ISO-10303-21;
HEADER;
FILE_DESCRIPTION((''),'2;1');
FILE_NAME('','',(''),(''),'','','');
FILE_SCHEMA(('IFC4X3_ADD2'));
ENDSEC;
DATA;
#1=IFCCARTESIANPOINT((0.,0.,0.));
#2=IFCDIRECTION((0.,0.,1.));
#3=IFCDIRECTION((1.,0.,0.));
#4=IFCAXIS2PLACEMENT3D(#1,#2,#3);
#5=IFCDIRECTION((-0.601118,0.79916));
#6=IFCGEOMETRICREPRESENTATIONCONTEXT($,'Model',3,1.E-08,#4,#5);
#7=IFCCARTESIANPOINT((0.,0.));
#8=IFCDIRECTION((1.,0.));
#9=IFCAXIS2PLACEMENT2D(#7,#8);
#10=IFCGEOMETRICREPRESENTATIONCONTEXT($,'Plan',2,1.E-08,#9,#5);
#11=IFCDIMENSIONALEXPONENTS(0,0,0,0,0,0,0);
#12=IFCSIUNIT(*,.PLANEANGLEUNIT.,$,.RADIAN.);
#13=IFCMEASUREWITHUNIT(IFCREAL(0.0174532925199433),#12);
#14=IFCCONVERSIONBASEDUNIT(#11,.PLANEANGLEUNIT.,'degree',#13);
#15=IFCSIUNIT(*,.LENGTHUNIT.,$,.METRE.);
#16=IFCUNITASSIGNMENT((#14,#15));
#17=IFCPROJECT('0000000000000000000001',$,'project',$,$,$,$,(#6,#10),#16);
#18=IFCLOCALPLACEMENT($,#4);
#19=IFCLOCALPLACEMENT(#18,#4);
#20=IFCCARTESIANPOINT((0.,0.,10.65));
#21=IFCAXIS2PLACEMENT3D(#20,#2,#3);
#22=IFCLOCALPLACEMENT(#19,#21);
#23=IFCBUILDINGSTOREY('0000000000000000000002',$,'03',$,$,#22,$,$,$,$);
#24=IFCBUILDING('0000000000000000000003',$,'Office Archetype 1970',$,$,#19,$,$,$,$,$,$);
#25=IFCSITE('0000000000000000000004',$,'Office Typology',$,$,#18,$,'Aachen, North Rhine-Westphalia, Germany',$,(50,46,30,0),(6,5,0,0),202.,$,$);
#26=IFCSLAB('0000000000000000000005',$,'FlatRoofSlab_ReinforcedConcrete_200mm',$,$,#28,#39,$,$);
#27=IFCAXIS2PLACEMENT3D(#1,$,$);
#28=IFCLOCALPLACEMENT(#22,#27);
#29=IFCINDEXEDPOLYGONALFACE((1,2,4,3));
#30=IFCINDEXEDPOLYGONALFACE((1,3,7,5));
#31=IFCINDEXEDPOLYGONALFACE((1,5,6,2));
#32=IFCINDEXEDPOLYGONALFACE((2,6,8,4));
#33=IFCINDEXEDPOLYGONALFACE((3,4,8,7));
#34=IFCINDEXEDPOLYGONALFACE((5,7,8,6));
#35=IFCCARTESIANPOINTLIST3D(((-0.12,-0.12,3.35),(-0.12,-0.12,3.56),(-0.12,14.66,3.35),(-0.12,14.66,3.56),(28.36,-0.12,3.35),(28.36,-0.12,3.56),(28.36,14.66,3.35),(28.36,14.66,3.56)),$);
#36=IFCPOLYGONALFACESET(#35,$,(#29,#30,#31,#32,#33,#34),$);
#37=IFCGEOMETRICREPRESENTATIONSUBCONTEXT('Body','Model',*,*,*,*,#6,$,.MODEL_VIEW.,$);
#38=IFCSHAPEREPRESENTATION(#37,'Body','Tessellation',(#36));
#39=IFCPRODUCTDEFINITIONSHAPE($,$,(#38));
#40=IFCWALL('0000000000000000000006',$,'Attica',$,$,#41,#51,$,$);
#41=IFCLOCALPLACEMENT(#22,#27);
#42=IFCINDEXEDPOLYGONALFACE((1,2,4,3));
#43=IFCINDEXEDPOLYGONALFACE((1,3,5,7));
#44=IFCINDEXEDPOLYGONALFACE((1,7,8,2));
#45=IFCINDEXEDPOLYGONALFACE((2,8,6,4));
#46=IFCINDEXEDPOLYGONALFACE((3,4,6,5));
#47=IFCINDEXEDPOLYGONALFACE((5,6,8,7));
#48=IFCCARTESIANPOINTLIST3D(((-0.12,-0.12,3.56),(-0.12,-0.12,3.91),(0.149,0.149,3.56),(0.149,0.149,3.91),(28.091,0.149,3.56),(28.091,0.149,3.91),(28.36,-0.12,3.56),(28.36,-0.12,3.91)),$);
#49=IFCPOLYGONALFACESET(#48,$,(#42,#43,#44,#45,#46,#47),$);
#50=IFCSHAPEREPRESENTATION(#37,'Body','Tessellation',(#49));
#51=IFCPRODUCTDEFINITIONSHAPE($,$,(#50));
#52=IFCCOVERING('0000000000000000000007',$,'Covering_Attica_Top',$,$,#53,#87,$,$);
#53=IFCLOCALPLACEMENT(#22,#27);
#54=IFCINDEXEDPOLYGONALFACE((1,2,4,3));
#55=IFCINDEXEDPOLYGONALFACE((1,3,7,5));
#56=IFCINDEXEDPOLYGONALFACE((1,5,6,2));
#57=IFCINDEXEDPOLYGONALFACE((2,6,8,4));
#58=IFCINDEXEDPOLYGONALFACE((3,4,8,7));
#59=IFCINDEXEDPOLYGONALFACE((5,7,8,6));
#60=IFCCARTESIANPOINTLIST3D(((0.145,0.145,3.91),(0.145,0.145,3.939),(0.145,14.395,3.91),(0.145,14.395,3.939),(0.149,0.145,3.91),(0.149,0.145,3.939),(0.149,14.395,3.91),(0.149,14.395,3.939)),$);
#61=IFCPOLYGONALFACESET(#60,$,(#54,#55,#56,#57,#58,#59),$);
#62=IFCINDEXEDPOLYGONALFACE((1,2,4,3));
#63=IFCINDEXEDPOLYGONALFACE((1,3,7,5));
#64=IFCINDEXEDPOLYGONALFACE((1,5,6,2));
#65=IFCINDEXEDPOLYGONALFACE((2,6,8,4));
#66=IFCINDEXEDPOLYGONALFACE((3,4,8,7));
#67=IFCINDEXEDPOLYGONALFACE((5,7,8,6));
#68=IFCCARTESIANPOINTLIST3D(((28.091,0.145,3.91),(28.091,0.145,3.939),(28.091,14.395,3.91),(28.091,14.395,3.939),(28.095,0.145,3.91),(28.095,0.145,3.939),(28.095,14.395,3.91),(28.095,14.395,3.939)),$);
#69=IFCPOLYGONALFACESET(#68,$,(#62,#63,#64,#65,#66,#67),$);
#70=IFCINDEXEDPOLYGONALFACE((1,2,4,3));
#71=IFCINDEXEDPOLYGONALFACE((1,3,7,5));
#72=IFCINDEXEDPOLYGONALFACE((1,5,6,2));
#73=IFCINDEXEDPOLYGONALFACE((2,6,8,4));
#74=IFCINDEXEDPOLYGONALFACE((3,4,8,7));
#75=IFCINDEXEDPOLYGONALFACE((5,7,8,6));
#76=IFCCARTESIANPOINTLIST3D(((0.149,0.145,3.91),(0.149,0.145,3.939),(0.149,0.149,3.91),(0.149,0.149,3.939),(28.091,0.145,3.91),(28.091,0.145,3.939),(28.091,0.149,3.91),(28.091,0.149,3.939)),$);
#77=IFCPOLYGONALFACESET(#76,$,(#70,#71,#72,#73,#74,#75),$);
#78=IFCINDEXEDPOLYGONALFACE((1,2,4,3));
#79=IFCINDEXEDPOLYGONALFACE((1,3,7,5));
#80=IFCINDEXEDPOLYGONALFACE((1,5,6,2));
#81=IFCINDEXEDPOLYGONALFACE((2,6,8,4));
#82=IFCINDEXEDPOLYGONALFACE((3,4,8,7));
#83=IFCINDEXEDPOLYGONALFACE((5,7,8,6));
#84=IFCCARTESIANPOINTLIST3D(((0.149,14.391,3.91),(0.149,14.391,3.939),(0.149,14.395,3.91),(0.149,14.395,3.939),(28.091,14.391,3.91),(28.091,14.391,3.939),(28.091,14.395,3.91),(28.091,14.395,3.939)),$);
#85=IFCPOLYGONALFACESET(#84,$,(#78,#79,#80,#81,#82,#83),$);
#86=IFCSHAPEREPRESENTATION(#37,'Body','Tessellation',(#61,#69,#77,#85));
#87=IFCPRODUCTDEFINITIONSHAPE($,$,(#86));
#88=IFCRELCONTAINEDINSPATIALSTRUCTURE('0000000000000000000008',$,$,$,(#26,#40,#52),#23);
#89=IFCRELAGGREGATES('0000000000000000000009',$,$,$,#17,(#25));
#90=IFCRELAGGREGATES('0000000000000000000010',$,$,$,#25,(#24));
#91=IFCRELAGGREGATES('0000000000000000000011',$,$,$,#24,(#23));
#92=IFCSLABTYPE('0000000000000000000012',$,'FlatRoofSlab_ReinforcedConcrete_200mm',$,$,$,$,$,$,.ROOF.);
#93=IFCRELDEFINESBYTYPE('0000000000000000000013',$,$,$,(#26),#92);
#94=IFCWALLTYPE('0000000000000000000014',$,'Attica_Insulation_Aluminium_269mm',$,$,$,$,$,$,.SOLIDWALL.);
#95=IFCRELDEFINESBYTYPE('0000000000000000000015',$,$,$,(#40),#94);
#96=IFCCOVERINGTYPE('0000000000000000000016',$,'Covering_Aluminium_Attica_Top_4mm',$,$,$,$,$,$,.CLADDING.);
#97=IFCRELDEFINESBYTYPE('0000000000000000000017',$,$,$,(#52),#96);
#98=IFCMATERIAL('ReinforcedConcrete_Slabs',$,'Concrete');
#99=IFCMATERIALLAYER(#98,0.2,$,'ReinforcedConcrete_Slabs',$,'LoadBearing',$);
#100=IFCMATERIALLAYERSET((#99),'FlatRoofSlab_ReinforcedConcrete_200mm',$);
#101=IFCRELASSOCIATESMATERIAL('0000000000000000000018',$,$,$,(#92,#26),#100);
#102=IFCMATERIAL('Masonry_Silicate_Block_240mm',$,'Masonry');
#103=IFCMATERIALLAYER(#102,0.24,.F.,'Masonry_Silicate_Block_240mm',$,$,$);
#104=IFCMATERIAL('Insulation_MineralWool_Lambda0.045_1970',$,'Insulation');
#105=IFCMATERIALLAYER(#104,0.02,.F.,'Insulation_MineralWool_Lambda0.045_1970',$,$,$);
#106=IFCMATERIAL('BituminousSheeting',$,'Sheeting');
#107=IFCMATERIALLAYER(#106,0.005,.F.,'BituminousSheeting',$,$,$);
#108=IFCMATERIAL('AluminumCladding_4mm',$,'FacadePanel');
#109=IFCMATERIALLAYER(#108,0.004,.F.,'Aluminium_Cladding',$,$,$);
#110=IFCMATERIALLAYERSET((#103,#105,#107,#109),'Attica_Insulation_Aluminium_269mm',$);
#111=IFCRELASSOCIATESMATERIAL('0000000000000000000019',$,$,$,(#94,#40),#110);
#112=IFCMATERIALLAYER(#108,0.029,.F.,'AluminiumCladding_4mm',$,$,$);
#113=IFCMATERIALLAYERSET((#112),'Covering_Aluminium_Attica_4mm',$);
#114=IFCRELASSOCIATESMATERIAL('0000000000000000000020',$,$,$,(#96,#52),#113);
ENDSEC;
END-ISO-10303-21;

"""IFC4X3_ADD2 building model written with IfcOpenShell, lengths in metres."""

from ifc_helpers import new_model, entity, si_unit, converted_unit, direction, frame, origin_with_axes, origin_2d_with_axis, place, context, subcontext, project, spatial, line, indexed_curve, outline, extrude, material, layer, layer_set, layer_usage, type_object, element, save


model = new_model("IFC4X3_ADD2")

# Units and contexts
model_context = context("Model", 3, precision=1e-08, world=origin_with_axes(), true_north=direction((-0.601118, 0.79916)))
plan_context = context("Plan", 2, precision=1e-08, world=origin_2d_with_axis(), true_north=direction((-0.601118, 0.79916)))
body_context = subcontext(model_context, "Body", "Model", "MODEL_VIEW")
ifc_project = project(units=[converted_unit("PLANEANGLEUNIT", "degree", entity("IfcReal", 0.0174532925199433), si_unit("PLANEANGLEUNIT", "RADIAN"), dimensions=[0, 0, 0, 0, 0, 0, 0]), si_unit("LENGTHUNIT", "METRE")], contexts=[model_context, plan_context])

# Site, building, storey
site_placement = place(None, origin_with_axes())
site = spatial("IfcSite", under=ifc_project, at=site_placement, Name="Office Typology", LongName="Aachen, North Rhine-Westphalia, Germany", RefLatitude=(50, 46, 30, 0), RefLongitude=(6, 5, 0, 0), RefElevation=202.0)
building_placement = place(site_placement, origin_with_axes())
building = spatial("IfcBuilding", under=site, at=building_placement, Name="Office Archetype 1970")
storey_placement = place(building_placement, frame((0.0, 0.0, 10.65), z_axis=(0.0, 0.0, 1.0), x_axis=(1.0, 0.0, 0.0)))
storey = spatial("IfcBuildingStorey", under=building, at=storey_placement, Name="03")

# Slab
ifc_material_1 = material(Name="ReinforcedConcrete_Slabs", Category="Concrete")
ifc_layer_1 = layer(ifc_material_1, 0.2, Name="ReinforcedConcrete_Slabs", Category="LoadBearing")
ifc_layer_set_1 = layer_set([ifc_layer_1], Name="FlatRoofSlab_ReinforcedConcrete_200mm")
ifc_layer_usage_1 = layer_usage(ifc_layer_set_1, "AXIS3", "POSITIVE", 0.0)
slab_type = type_object("IfcSlabType", Name="FlatRoofSlab_ReinforcedConcrete_200mm", PredefinedType="ROOF", material=ifc_layer_set_1)
slab_placement = place(storey_placement, frame((-0.12, -0.12, 3.35), z_axis=(0.0, 0.0, 1.0), x_axis=(1.0, 0.0, 0.0)))
element("IfcSlab", 1, at=slab_placement, inside=storey, type_object=slab_type, material=ifc_layer_usage_1, Name="FlatRoofSlab_ReinforcedConcrete_200mm", context=body_context, shape_type="SweptSolid", body=[
    extrude(outline(indexed_curve([(0.0, 0.0), (28.48, 0.0), (28.48, 14.78), (0.0, 14.78), (0.0, 0.0)])), None, (0.0, 0.0, 1.0), 0.21),
])

# Shared definitions
ifc_material_2 = material(Name="Insulation_MineralWool_Lambda0.045_1970", Category="Insulation")

# Wall
ifc_material_3 = material(Name="Masonry_Silicate_Block_240mm", Category="Masonry")
ifc_layer_2 = layer(ifc_material_3, 0.24, ventilated=False, Name="Masonry_Silicate_Block_240mm")
ifc_layer_3 = layer(ifc_material_2, 0.02, ventilated=False, Name="Insulation_MineralWool_Lambda0.045_1970")
ifc_material_4 = material(Name="BituminousSheeting", Category="Sheeting")
ifc_layer_4 = layer(ifc_material_4, 0.005, ventilated=False, Name="BituminousSheeting")
ifc_material_5 = material(Name="AluminumCladding_4mm", Category="FacadePanel")
ifc_layer_5 = layer(ifc_material_5, 0.004, ventilated=False, Name="Aluminium_Cladding")
ifc_layer_set_2 = layer_set([ifc_layer_2, ifc_layer_3, ifc_layer_4, ifc_layer_5], Name="Attica_Insulation_Aluminium_269mm")
ifc_layer_usage_2 = layer_usage(ifc_layer_set_2, "AXIS2", "POSITIVE", 0.0)
wall_type = type_object("IfcWallType", Name="Attica_Insulation_Aluminium_269mm", PredefinedType="SOLIDWALL", material=ifc_layer_set_2)
wall_placement = place(storey_placement, frame((-0.12, -0.12, 3.56), z_axis=(0.0, 0.0, 1.0), x_axis=(1.0, 0.0, 0.0)))
element("IfcWall", 2, at=wall_placement, inside=storey, type_object=wall_type, material=ifc_layer_usage_2, Name="Attica", context=body_context, shape_type="SweptSolid", body=[
    extrude(outline(indexed_curve([(0.0, 0.0), (0.269, 0.269), (28.211, 0.269), (28.48, 0.0)], segments=[line(1, 2, 3, 4, 1)])), origin_with_axes(), (0.0, 0.0, 1.0), 0.35),
])

# Covering
ifc_layer_6 = layer(ifc_material_5, 0.029, ventilated=False, Name="AluminiumCladding_4mm")
ifc_layer_set_3 = layer_set([ifc_layer_6], Name="Covering_Aluminium_Attica_4mm")
ifc_layer_usage_3 = layer_usage(ifc_layer_set_3, "AXIS3", "POSITIVE", 0.0)
covering_type_1 = type_object("IfcCoveringType", Name="Covering_Aluminium_Attica_Top_4mm", PredefinedType="CLADDING", material=ifc_layer_set_3)
covering_1_placement = place(storey_placement, frame((0.0, 0.0, 3.91), z_axis=(0.0, 0.0, 1.0), x_axis=(1.0, 0.0, 0.0)))
element("IfcCovering", 3, at=covering_1_placement, inside=storey, type_object=covering_type_1, material=ifc_layer_usage_3, Name="Covering_Attica_Top", context=body_context, shape_type="SweptSolid", body=[
    extrude(outline(indexed_curve([(0.145, 0.145), (0.149, 0.145), (0.149, 14.395), (0.145, 14.395), (0.145, 0.145)])), origin_with_axes(), (0.0, 0.0, 1.0), 0.029),
    extrude(outline(indexed_curve([(0.145, 0.145), (0.149, 0.145), (0.149, 14.395), (0.145, 14.395), (0.145, 0.145)])), frame((27.946, 0.0, 0.0), z_axis=(0.0, 0.0, 1.0), x_axis=(1.0, 0.0, 0.0)), (0.0, 0.0, 1.0), 0.029),
    extrude(outline(indexed_curve([(0.145, 27.797), (0.149, 27.797), (0.149, -0.145), (0.145, -0.145), (0.145, 27.797)])), frame((27.946, 0.0, 0.0), z_axis=(0.0, 0.0, 1.0), x_axis=(0.0, 1.0, 0.0)), (0.0, 0.0, 1.0), 0.029),
    extrude(outline(indexed_curve([(0.145, 27.797), (0.149, 27.797), (0.149, -0.145), (0.145, -0.145), (0.145, 27.797)])), frame((27.946, 14.246, 0.0), z_axis=(0.0, 0.0, 1.0), x_axis=(0.0, 1.0, 0.0)), (0.0, 0.0, 1.0), 0.029),
])

save(model, "model.ifc")
